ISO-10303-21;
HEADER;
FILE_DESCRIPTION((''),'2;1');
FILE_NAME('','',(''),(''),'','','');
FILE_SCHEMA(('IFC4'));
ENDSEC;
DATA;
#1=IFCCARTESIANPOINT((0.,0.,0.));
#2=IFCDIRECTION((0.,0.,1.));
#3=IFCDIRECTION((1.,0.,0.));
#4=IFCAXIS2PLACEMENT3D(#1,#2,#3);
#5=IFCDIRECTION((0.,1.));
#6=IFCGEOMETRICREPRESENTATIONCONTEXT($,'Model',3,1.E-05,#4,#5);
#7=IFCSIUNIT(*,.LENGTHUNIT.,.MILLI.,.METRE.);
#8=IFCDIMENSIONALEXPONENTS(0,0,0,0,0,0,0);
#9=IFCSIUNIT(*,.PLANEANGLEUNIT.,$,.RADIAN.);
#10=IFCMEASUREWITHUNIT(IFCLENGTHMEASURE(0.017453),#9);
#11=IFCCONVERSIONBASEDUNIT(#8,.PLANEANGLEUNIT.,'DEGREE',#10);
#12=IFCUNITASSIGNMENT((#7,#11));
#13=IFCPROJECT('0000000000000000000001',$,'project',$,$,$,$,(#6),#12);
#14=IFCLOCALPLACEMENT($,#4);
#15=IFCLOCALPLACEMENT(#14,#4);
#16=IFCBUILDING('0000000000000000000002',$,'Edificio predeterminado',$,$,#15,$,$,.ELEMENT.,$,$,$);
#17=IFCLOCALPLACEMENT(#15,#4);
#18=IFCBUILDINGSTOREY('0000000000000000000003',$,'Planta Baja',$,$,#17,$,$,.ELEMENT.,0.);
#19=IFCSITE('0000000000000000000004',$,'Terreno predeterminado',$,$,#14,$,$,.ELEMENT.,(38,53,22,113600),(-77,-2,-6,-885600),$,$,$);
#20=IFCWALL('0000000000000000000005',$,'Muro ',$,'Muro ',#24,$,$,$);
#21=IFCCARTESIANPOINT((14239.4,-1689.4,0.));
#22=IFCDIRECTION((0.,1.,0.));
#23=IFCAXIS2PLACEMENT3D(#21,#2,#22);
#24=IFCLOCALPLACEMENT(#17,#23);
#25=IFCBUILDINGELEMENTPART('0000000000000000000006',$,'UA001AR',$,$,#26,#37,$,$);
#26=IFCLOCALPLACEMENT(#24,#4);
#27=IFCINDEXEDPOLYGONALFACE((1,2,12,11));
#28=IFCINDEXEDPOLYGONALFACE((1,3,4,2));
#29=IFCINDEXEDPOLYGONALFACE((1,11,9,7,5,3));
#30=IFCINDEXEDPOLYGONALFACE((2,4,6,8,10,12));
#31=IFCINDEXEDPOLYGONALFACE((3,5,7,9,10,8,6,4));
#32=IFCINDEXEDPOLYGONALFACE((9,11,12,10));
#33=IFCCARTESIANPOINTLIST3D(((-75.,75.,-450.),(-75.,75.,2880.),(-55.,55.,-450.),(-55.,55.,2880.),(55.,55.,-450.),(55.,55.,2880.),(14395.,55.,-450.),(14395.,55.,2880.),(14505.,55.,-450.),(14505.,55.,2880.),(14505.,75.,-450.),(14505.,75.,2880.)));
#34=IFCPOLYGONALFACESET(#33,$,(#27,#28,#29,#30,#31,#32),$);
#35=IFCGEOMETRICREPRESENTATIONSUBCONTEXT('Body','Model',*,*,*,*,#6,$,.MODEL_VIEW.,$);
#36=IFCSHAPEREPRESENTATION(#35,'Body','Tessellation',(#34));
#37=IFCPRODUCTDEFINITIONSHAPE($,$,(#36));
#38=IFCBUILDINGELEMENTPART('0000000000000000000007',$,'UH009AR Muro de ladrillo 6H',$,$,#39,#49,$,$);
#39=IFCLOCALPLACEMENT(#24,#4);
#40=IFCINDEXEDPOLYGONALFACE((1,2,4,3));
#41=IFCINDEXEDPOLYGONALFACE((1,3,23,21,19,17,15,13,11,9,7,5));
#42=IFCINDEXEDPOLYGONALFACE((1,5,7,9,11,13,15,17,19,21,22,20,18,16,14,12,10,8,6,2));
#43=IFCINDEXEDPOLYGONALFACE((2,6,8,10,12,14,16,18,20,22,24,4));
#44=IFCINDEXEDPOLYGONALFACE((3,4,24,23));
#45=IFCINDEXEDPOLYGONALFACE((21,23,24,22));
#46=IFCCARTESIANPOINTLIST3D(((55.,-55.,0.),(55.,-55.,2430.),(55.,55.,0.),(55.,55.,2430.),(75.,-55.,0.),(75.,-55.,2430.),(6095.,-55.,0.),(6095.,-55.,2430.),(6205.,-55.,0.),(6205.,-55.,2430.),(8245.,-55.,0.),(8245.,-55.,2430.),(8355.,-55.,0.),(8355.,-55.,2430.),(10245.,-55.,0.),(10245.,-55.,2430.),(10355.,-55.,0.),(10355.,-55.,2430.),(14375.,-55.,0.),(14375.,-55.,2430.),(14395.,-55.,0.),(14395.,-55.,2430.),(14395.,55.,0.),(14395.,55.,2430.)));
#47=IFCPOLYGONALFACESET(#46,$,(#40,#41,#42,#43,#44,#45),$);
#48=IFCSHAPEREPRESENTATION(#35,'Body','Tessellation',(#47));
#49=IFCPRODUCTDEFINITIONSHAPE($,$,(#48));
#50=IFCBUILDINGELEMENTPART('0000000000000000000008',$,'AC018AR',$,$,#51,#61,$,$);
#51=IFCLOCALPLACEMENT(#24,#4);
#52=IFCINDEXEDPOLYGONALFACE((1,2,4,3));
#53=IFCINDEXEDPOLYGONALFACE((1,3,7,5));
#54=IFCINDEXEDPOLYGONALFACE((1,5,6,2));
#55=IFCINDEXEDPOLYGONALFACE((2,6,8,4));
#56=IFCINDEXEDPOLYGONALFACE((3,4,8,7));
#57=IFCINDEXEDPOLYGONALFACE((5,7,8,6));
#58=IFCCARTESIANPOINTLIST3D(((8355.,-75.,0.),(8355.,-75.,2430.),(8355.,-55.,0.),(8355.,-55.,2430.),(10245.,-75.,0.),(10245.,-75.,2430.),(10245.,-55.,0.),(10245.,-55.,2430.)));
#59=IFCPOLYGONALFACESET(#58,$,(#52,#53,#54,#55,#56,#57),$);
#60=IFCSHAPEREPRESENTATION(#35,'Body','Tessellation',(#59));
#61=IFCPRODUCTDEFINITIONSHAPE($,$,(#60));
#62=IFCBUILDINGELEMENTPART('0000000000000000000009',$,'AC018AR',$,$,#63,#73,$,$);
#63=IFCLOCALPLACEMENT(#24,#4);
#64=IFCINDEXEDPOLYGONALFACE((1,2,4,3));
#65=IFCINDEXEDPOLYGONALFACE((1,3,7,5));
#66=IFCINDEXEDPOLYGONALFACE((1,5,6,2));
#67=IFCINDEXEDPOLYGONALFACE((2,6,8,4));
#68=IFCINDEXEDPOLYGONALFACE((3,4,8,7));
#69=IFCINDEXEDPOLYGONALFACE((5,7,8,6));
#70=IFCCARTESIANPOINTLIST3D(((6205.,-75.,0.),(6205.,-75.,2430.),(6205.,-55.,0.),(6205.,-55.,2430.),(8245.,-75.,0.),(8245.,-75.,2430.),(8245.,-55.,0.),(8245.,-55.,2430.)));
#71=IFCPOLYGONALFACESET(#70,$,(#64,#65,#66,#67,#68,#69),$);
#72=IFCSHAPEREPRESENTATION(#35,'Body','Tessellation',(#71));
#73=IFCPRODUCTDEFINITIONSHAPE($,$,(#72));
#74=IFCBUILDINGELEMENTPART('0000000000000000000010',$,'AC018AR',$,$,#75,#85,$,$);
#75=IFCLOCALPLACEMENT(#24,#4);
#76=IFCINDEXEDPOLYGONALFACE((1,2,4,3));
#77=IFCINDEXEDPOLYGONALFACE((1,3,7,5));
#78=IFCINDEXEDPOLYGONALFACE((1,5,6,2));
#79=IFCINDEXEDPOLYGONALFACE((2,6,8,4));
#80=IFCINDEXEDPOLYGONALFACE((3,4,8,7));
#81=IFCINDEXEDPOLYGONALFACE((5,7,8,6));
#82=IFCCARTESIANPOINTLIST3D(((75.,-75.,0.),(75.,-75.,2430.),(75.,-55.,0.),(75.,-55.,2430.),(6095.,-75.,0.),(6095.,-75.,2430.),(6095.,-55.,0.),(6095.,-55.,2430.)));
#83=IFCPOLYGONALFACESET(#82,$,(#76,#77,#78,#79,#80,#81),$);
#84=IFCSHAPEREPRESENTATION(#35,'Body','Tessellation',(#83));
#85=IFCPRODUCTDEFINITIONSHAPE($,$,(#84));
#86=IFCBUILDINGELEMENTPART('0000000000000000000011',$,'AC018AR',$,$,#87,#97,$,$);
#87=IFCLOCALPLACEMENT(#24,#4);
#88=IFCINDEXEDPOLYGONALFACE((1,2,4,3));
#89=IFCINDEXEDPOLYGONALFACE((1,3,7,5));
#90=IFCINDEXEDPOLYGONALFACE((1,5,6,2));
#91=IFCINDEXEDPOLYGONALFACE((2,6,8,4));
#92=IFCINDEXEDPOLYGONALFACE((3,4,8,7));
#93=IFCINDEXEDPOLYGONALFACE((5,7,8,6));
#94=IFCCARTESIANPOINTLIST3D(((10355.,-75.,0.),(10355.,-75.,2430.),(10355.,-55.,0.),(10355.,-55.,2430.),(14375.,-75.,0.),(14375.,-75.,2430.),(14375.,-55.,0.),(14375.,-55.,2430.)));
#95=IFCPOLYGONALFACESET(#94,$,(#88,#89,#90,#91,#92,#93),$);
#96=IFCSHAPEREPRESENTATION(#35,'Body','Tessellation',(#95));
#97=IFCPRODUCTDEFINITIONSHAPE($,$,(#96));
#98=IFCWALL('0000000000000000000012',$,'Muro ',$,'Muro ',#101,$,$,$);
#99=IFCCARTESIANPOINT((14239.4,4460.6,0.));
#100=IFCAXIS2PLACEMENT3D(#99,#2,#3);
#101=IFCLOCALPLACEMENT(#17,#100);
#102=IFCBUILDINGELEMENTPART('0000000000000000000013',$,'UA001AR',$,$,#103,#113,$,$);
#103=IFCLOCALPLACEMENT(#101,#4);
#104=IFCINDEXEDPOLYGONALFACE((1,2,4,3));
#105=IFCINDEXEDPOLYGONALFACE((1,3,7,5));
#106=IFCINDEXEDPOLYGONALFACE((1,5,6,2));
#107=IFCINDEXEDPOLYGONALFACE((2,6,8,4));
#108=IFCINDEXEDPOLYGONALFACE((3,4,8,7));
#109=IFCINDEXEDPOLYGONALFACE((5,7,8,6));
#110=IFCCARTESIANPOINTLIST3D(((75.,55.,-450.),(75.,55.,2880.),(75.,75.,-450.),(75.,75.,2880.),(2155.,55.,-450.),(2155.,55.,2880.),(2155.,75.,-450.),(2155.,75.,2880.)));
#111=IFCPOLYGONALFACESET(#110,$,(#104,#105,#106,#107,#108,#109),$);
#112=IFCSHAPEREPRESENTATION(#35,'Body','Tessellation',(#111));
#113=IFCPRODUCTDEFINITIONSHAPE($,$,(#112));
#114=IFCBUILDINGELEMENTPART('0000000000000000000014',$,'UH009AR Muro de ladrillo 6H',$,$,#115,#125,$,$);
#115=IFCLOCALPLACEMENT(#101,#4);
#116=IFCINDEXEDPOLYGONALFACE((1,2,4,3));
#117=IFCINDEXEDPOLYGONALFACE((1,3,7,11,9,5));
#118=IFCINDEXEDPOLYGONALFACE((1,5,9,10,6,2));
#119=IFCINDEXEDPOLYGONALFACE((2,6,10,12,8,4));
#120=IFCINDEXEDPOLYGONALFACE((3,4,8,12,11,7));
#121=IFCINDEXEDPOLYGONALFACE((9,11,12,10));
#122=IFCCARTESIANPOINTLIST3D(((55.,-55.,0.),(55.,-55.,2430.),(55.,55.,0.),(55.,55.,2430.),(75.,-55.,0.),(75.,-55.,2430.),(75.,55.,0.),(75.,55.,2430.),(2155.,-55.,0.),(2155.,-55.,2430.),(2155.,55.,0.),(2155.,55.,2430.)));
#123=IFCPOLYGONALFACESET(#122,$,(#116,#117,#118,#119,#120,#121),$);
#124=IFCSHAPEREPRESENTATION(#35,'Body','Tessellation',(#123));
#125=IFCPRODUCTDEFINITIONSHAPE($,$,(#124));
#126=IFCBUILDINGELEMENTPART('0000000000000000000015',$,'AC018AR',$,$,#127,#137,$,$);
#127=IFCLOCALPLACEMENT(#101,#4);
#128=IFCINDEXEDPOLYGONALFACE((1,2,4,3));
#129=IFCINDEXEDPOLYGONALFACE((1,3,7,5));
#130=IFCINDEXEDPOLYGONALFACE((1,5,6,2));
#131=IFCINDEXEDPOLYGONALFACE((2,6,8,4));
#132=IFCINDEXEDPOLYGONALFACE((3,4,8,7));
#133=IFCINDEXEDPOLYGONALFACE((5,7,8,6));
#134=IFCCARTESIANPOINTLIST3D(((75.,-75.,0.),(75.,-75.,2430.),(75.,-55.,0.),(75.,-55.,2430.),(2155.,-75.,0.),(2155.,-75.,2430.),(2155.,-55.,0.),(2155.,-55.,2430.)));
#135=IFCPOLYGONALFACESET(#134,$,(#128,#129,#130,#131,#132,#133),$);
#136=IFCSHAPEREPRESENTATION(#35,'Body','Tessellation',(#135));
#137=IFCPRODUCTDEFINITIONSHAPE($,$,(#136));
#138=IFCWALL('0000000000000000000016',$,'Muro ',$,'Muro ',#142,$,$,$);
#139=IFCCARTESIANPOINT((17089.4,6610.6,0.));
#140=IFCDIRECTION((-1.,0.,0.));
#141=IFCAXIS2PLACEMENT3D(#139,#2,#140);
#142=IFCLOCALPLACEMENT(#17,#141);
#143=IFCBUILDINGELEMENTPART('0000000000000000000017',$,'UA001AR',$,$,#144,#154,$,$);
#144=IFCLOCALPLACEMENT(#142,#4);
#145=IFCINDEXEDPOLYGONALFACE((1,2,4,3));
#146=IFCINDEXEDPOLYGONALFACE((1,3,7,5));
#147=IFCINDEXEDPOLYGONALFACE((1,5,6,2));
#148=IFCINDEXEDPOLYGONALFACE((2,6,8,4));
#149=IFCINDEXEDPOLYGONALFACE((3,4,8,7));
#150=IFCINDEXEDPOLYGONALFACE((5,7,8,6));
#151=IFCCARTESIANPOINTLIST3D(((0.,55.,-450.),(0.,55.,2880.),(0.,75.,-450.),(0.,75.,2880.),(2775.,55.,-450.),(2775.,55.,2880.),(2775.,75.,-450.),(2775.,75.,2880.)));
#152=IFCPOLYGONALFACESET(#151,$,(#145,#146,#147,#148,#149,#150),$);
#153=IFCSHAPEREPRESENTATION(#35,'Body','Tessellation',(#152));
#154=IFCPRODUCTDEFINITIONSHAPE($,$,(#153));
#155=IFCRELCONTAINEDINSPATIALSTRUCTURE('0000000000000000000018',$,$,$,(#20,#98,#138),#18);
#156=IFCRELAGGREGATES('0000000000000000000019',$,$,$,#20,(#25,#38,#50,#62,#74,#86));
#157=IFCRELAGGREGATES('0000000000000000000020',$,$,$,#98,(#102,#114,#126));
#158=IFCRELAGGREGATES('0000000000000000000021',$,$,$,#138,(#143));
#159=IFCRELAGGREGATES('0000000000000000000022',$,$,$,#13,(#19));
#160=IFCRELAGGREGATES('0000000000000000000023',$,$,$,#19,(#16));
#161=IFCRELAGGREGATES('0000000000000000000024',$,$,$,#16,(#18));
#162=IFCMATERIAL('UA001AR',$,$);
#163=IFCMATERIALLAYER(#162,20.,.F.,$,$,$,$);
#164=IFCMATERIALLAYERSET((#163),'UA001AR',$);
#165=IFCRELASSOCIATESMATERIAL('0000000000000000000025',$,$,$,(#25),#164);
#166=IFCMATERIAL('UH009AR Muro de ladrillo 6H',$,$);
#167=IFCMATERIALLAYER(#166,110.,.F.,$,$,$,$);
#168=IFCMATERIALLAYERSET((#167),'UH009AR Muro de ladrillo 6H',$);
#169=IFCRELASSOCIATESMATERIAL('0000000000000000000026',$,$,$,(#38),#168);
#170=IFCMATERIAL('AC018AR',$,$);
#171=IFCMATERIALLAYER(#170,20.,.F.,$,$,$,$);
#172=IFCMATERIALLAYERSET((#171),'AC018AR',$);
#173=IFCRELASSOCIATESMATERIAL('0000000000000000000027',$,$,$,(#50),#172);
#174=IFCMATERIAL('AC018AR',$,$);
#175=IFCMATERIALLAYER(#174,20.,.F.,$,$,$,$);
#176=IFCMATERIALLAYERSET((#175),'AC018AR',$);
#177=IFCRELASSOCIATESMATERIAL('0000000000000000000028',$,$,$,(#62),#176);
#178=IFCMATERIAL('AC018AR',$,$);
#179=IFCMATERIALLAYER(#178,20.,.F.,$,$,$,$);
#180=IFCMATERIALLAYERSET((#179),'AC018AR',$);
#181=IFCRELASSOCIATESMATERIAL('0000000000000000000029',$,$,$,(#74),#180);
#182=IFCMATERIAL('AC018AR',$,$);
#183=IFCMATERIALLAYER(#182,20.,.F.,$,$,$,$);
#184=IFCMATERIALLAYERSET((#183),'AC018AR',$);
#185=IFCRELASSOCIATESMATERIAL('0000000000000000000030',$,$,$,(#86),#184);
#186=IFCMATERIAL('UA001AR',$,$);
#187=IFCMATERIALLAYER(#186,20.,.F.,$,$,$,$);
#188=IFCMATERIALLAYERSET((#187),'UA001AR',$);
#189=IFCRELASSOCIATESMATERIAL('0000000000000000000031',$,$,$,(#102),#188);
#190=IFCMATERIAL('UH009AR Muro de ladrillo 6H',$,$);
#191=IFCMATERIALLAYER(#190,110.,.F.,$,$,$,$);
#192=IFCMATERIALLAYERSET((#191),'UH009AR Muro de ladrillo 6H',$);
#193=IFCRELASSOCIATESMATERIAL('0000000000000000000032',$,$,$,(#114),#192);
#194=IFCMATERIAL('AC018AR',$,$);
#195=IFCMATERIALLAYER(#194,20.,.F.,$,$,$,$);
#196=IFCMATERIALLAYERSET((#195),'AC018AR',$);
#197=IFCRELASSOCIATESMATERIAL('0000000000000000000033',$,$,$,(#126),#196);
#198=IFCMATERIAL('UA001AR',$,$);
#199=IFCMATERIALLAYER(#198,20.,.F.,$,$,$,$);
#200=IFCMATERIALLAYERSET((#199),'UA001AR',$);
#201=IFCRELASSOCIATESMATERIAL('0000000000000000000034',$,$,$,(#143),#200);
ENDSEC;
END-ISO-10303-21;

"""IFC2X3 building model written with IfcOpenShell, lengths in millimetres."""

from ifc_helpers import new_model, entity, si_unit, converted_unit, direction, frame, origin_with_axes, place, context, subcontext, project, spatial, polyline, outline, extrude, material, layer, layer_set, layer_usage, element, aggregate, save


model = new_model("IFC2X3")

# Units and contexts
model_context = context("Model", 3, precision=1e-05, world=origin_with_axes(), true_north=direction((0.0, 1.0)))
body_context = subcontext(model_context, "Body", "Model", "MODEL_VIEW")
ifc_project = project(units=[si_unit("LENGTHUNIT", "METRE", prefix="MILLI"), converted_unit("PLANEANGLEUNIT", "DEGREE", entity("IfcLengthMeasure", 0.017453), si_unit("PLANEANGLEUNIT", "RADIAN"), dimensions=[0, 0, 0, 0, 0, 0, 0])], contexts=[model_context])

# Site, building, storey
site_placement = place(None, origin_with_axes())
site = spatial("IfcSite", under=ifc_project, at=site_placement, Name="Terreno predeterminado", CompositionType="ELEMENT", RefLatitude=(38, 53, 22, 113600), RefLongitude=(-77, -2, -6, -885600))
building_placement = place(site_placement, origin_with_axes())
building = spatial("IfcBuilding", under=site, at=building_placement, Name="Edificio predeterminado", CompositionType="ELEMENT")
storey_placement = place(building_placement, origin_with_axes())
storey = spatial("IfcBuildingStorey", under=building, at=storey_placement, Name="Planta Baja", CompositionType="ELEMENT", Elevation=0.0)

# Walls, building element parts
wall_1_placement = place(storey_placement, frame((14239.4, -1689.4, 0.0), z_axis=(0.0, 0.0, 1.0), x_axis=(0.0, 1.0, 0.0)))
wall_1 = element("IfcWall", 1, at=wall_1_placement, inside=storey, Name="Muro ", ObjectType="Muro ")
ifc_material_1 = material(Name="UA001AR")
ifc_layer_1 = layer(ifc_material_1, 20.0, ventilated=False)
ifc_layer_set_1 = layer_set([ifc_layer_1], Name="UA001AR")
ifc_layer_usage_1 = layer_usage(ifc_layer_set_1, "AXIS2", "NEGATIVE", -75.0)
building_element_part_1_placement = place(wall_1_placement, origin_with_axes())
building_element_part_1 = element("IfcBuildingElementPart", 2, at=building_element_part_1_placement, material=ifc_layer_usage_1, Name="UA001AR", context=body_context, shape_type="SweptSolid", body=[
    extrude(outline(polyline([(14505.0, 75.0), (14505.0, 55.0), (14395.0, 55.0), (55.0, 55.0), (-55.0, 55.0), (-75.0, 75.0), (14505.0, 75.0)])), frame((0.0, 0.0, -450.0), z_axis=(0.0, 0.0, 1.0), x_axis=(1.0, 0.0, 0.0)), (0.0, 0.0, 1.0), 3330.0),
])
ifc_material_2 = material(Name="UH009AR Muro de ladrillo 6H")
ifc_layer_2 = layer(ifc_material_2, 110.0, ventilated=False)
ifc_layer_set_2 = layer_set([ifc_layer_2], Name="UH009AR Muro de ladrillo 6H")
ifc_layer_usage_2 = layer_usage(ifc_layer_set_2, "AXIS2", "NEGATIVE", -55.0)
building_element_part_2_placement = place(wall_1_placement, origin_with_axes())
building_element_part_2 = element("IfcBuildingElementPart", 3, at=building_element_part_2_placement, material=ifc_layer_usage_2, Name="UH009AR Muro de ladrillo 6H", context=body_context, shape_type="SweptSolid", body=[
    extrude(outline(polyline([(14395.0, 55.0), (14395.0, -55.0), (14375.0, -55.0), (10355.0, -55.0), (10245.0, -55.0), (8355.0, -55.0), (8245.0, -55.0), (6205.0, -55.0), (6095.0, -55.0), (75.0, -55.0), (55.0, -55.0), (55.0, 55.0), (14395.0, 55.0)])), origin_with_axes(), (0.0, 0.0, 1.0), 2430.0),
])
ifc_material_3 = material(Name="AC018AR")
ifc_layer_3 = layer(ifc_material_3, 20.0, ventilated=False)
ifc_layer_set_3 = layer_set([ifc_layer_3], Name="AC018AR")
ifc_layer_usage_3 = layer_usage(ifc_layer_set_3, "AXIS2", "NEGATIVE", 55.0)
building_element_part_3_placement = place(wall_1_placement, origin_with_axes())
building_element_part_3 = element("IfcBuildingElementPart", 4, at=building_element_part_3_placement, material=ifc_layer_usage_3, Name="AC018AR", context=body_context, shape_type="SweptSolid", body=[
    extrude(outline(polyline([(8355.0, -55.0), (10245.0, -55.0), (10245.0, -75.0), (8355.0, -75.0), (8355.0, -55.0)])), origin_with_axes(), (0.0, 0.0, 1.0), 2430.0),
])
ifc_material_4 = material(Name="AC018AR")
ifc_layer_4 = layer(ifc_material_4, 20.0, ventilated=False)
ifc_layer_set_4 = layer_set([ifc_layer_4], Name="AC018AR")
ifc_layer_usage_4 = layer_usage(ifc_layer_set_4, "AXIS2", "NEGATIVE", 55.0)
building_element_part_4_placement = place(wall_1_placement, origin_with_axes())
building_element_part_4 = element("IfcBuildingElementPart", 5, at=building_element_part_4_placement, material=ifc_layer_usage_4, Name="AC018AR", context=body_context, shape_type="SweptSolid", body=[
    extrude(outline(polyline([(8245.0, -55.0), (8245.0, -75.0), (6205.0, -75.0), (6205.0, -55.0), (8245.0, -55.0)])), origin_with_axes(), (0.0, 0.0, 1.0), 2430.0),
])
ifc_material_5 = material(Name="AC018AR")
ifc_layer_5 = layer(ifc_material_5, 20.0, ventilated=False)
ifc_layer_set_5 = layer_set([ifc_layer_5], Name="AC018AR")
ifc_layer_usage_5 = layer_usage(ifc_layer_set_5, "AXIS2", "NEGATIVE", 55.0)
building_element_part_5_placement = place(wall_1_placement, origin_with_axes())
building_element_part_5 = element("IfcBuildingElementPart", 6, at=building_element_part_5_placement, material=ifc_layer_usage_5, Name="AC018AR", context=body_context, shape_type="SweptSolid", body=[
    extrude(outline(polyline([(6095.0, -55.0), (6095.0, -75.0), (75.0, -75.0), (75.0, -55.0), (6095.0, -55.0)])), origin_with_axes(), (0.0, 0.0, 1.0), 2430.0),
])
ifc_material_6 = material(Name="AC018AR")
ifc_layer_6 = layer(ifc_material_6, 20.0, ventilated=False)
ifc_layer_set_6 = layer_set([ifc_layer_6], Name="AC018AR")
ifc_layer_usage_6 = layer_usage(ifc_layer_set_6, "AXIS2", "NEGATIVE", 55.0)
building_element_part_6_placement = place(wall_1_placement, origin_with_axes())
building_element_part_6 = element("IfcBuildingElementPart", 7, at=building_element_part_6_placement, material=ifc_layer_usage_6, Name="AC018AR", context=body_context, shape_type="SweptSolid", body=[
    extrude(outline(polyline([(14375.0, -55.0), (14375.0, -75.0), (10355.0, -75.0), (10355.0, -55.0), (14375.0, -55.0)])), origin_with_axes(), (0.0, 0.0, 1.0), 2430.0),
])
aggregate(wall_1, [building_element_part_1, building_element_part_2, building_element_part_3, building_element_part_4, building_element_part_5, building_element_part_6])
wall_2_placement = place(storey_placement, frame((14239.4, 4460.6, 0.0), z_axis=(0.0, 0.0, 1.0), x_axis=(1.0, 0.0, 0.0)))
wall_2 = element("IfcWall", 8, at=wall_2_placement, inside=storey, Name="Muro ", ObjectType="Muro ")
ifc_material_7 = material(Name="UA001AR")
ifc_layer_7 = layer(ifc_material_7, 20.0, ventilated=False)
ifc_layer_set_7 = layer_set([ifc_layer_7], Name="UA001AR")
ifc_layer_usage_7 = layer_usage(ifc_layer_set_7, "AXIS2", "NEGATIVE", -75.0)
building_element_part_7_placement = place(wall_2_placement, origin_with_axes())
building_element_part_7 = element("IfcBuildingElementPart", 9, at=building_element_part_7_placement, material=ifc_layer_usage_7, Name="UA001AR", context=body_context, shape_type="SweptSolid", body=[
    extrude(outline(polyline([(2155.0, 75.0), (2155.0, 55.0), (75.0, 55.0), (75.0, 75.0), (2155.0, 75.0)])), frame((0.0, 0.0, -450.0), z_axis=(0.0, 0.0, 1.0), x_axis=(1.0, 0.0, 0.0)), (0.0, 0.0, 1.0), 3330.0),
])
ifc_material_8 = material(Name="UH009AR Muro de ladrillo 6H")
ifc_layer_8 = layer(ifc_material_8, 110.0, ventilated=False)
ifc_layer_set_8 = layer_set([ifc_layer_8], Name="UH009AR Muro de ladrillo 6H")
ifc_layer_usage_8 = layer_usage(ifc_layer_set_8, "AXIS2", "NEGATIVE", -55.0)
building_element_part_8_placement = place(wall_2_placement, origin_with_axes())
building_element_part_8 = element("IfcBuildingElementPart", 10, at=building_element_part_8_placement, material=ifc_layer_usage_8, Name="UH009AR Muro de ladrillo 6H", context=body_context, shape_type="SweptSolid", body=[
    extrude(outline(polyline([(2155.0, 55.0), (2155.0, -55.0), (75.0, -55.0), (55.0, -55.0), (55.0, 55.0), (75.0, 55.0), (2155.0, 55.0)])), origin_with_axes(), (0.0, 0.0, 1.0), 2430.0),
])
ifc_material_9 = material(Name="AC018AR")
ifc_layer_9 = layer(ifc_material_9, 20.0, ventilated=False)
ifc_layer_set_9 = layer_set([ifc_layer_9], Name="AC018AR")
ifc_layer_usage_9 = layer_usage(ifc_layer_set_9, "AXIS2", "NEGATIVE", 55.0)
building_element_part_9_placement = place(wall_2_placement, origin_with_axes())
building_element_part_9 = element("IfcBuildingElementPart", 11, at=building_element_part_9_placement, material=ifc_layer_usage_9, Name="AC018AR", context=body_context, shape_type="SweptSolid", body=[
    extrude(outline(polyline([(2155.0, -55.0), (2155.0, -75.0), (75.0, -75.0), (75.0, -55.0), (2155.0, -55.0)])), origin_with_axes(), (0.0, 0.0, 1.0), 2430.0),
])
aggregate(wall_2, [building_element_part_7, building_element_part_8, building_element_part_9])

# Wall, building element part
wall_3_placement = place(storey_placement, frame((17089.4, 6610.6, 0.0), z_axis=(0.0, 0.0, 1.0), x_axis=(-1.0, 0.0, 0.0)))
wall_3 = element("IfcWall", 12, at=wall_3_placement, inside=storey, Name="Muro ", ObjectType="Muro ")
ifc_material_10 = material(Name="UA001AR")
ifc_layer_10 = layer(ifc_material_10, 20.0, ventilated=False)
ifc_layer_set_10 = layer_set([ifc_layer_10], Name="UA001AR")
ifc_layer_usage_10 = layer_usage(ifc_layer_set_10, "AXIS2", "NEGATIVE", -75.0)
building_element_part_10_placement = place(wall_3_placement, origin_with_axes())
building_element_part_10 = element("IfcBuildingElementPart", 13, at=building_element_part_10_placement, material=ifc_layer_usage_10, Name="UA001AR", context=body_context, shape_type="SweptSolid", body=[
    extrude(outline(polyline([(0.0, 75.0), (2775.0, 75.0), (2775.0, 55.0), (0.0, 55.0), (0.0, 75.0)])), frame((0.0, 0.0, -450.0), z_axis=(0.0, 0.0, 1.0), x_axis=(1.0, 0.0, 0.0)), (0.0, 0.0, 1.0), 3330.0),
])
aggregate(wall_3, [building_element_part_10])

save(model, "model.ifc")
